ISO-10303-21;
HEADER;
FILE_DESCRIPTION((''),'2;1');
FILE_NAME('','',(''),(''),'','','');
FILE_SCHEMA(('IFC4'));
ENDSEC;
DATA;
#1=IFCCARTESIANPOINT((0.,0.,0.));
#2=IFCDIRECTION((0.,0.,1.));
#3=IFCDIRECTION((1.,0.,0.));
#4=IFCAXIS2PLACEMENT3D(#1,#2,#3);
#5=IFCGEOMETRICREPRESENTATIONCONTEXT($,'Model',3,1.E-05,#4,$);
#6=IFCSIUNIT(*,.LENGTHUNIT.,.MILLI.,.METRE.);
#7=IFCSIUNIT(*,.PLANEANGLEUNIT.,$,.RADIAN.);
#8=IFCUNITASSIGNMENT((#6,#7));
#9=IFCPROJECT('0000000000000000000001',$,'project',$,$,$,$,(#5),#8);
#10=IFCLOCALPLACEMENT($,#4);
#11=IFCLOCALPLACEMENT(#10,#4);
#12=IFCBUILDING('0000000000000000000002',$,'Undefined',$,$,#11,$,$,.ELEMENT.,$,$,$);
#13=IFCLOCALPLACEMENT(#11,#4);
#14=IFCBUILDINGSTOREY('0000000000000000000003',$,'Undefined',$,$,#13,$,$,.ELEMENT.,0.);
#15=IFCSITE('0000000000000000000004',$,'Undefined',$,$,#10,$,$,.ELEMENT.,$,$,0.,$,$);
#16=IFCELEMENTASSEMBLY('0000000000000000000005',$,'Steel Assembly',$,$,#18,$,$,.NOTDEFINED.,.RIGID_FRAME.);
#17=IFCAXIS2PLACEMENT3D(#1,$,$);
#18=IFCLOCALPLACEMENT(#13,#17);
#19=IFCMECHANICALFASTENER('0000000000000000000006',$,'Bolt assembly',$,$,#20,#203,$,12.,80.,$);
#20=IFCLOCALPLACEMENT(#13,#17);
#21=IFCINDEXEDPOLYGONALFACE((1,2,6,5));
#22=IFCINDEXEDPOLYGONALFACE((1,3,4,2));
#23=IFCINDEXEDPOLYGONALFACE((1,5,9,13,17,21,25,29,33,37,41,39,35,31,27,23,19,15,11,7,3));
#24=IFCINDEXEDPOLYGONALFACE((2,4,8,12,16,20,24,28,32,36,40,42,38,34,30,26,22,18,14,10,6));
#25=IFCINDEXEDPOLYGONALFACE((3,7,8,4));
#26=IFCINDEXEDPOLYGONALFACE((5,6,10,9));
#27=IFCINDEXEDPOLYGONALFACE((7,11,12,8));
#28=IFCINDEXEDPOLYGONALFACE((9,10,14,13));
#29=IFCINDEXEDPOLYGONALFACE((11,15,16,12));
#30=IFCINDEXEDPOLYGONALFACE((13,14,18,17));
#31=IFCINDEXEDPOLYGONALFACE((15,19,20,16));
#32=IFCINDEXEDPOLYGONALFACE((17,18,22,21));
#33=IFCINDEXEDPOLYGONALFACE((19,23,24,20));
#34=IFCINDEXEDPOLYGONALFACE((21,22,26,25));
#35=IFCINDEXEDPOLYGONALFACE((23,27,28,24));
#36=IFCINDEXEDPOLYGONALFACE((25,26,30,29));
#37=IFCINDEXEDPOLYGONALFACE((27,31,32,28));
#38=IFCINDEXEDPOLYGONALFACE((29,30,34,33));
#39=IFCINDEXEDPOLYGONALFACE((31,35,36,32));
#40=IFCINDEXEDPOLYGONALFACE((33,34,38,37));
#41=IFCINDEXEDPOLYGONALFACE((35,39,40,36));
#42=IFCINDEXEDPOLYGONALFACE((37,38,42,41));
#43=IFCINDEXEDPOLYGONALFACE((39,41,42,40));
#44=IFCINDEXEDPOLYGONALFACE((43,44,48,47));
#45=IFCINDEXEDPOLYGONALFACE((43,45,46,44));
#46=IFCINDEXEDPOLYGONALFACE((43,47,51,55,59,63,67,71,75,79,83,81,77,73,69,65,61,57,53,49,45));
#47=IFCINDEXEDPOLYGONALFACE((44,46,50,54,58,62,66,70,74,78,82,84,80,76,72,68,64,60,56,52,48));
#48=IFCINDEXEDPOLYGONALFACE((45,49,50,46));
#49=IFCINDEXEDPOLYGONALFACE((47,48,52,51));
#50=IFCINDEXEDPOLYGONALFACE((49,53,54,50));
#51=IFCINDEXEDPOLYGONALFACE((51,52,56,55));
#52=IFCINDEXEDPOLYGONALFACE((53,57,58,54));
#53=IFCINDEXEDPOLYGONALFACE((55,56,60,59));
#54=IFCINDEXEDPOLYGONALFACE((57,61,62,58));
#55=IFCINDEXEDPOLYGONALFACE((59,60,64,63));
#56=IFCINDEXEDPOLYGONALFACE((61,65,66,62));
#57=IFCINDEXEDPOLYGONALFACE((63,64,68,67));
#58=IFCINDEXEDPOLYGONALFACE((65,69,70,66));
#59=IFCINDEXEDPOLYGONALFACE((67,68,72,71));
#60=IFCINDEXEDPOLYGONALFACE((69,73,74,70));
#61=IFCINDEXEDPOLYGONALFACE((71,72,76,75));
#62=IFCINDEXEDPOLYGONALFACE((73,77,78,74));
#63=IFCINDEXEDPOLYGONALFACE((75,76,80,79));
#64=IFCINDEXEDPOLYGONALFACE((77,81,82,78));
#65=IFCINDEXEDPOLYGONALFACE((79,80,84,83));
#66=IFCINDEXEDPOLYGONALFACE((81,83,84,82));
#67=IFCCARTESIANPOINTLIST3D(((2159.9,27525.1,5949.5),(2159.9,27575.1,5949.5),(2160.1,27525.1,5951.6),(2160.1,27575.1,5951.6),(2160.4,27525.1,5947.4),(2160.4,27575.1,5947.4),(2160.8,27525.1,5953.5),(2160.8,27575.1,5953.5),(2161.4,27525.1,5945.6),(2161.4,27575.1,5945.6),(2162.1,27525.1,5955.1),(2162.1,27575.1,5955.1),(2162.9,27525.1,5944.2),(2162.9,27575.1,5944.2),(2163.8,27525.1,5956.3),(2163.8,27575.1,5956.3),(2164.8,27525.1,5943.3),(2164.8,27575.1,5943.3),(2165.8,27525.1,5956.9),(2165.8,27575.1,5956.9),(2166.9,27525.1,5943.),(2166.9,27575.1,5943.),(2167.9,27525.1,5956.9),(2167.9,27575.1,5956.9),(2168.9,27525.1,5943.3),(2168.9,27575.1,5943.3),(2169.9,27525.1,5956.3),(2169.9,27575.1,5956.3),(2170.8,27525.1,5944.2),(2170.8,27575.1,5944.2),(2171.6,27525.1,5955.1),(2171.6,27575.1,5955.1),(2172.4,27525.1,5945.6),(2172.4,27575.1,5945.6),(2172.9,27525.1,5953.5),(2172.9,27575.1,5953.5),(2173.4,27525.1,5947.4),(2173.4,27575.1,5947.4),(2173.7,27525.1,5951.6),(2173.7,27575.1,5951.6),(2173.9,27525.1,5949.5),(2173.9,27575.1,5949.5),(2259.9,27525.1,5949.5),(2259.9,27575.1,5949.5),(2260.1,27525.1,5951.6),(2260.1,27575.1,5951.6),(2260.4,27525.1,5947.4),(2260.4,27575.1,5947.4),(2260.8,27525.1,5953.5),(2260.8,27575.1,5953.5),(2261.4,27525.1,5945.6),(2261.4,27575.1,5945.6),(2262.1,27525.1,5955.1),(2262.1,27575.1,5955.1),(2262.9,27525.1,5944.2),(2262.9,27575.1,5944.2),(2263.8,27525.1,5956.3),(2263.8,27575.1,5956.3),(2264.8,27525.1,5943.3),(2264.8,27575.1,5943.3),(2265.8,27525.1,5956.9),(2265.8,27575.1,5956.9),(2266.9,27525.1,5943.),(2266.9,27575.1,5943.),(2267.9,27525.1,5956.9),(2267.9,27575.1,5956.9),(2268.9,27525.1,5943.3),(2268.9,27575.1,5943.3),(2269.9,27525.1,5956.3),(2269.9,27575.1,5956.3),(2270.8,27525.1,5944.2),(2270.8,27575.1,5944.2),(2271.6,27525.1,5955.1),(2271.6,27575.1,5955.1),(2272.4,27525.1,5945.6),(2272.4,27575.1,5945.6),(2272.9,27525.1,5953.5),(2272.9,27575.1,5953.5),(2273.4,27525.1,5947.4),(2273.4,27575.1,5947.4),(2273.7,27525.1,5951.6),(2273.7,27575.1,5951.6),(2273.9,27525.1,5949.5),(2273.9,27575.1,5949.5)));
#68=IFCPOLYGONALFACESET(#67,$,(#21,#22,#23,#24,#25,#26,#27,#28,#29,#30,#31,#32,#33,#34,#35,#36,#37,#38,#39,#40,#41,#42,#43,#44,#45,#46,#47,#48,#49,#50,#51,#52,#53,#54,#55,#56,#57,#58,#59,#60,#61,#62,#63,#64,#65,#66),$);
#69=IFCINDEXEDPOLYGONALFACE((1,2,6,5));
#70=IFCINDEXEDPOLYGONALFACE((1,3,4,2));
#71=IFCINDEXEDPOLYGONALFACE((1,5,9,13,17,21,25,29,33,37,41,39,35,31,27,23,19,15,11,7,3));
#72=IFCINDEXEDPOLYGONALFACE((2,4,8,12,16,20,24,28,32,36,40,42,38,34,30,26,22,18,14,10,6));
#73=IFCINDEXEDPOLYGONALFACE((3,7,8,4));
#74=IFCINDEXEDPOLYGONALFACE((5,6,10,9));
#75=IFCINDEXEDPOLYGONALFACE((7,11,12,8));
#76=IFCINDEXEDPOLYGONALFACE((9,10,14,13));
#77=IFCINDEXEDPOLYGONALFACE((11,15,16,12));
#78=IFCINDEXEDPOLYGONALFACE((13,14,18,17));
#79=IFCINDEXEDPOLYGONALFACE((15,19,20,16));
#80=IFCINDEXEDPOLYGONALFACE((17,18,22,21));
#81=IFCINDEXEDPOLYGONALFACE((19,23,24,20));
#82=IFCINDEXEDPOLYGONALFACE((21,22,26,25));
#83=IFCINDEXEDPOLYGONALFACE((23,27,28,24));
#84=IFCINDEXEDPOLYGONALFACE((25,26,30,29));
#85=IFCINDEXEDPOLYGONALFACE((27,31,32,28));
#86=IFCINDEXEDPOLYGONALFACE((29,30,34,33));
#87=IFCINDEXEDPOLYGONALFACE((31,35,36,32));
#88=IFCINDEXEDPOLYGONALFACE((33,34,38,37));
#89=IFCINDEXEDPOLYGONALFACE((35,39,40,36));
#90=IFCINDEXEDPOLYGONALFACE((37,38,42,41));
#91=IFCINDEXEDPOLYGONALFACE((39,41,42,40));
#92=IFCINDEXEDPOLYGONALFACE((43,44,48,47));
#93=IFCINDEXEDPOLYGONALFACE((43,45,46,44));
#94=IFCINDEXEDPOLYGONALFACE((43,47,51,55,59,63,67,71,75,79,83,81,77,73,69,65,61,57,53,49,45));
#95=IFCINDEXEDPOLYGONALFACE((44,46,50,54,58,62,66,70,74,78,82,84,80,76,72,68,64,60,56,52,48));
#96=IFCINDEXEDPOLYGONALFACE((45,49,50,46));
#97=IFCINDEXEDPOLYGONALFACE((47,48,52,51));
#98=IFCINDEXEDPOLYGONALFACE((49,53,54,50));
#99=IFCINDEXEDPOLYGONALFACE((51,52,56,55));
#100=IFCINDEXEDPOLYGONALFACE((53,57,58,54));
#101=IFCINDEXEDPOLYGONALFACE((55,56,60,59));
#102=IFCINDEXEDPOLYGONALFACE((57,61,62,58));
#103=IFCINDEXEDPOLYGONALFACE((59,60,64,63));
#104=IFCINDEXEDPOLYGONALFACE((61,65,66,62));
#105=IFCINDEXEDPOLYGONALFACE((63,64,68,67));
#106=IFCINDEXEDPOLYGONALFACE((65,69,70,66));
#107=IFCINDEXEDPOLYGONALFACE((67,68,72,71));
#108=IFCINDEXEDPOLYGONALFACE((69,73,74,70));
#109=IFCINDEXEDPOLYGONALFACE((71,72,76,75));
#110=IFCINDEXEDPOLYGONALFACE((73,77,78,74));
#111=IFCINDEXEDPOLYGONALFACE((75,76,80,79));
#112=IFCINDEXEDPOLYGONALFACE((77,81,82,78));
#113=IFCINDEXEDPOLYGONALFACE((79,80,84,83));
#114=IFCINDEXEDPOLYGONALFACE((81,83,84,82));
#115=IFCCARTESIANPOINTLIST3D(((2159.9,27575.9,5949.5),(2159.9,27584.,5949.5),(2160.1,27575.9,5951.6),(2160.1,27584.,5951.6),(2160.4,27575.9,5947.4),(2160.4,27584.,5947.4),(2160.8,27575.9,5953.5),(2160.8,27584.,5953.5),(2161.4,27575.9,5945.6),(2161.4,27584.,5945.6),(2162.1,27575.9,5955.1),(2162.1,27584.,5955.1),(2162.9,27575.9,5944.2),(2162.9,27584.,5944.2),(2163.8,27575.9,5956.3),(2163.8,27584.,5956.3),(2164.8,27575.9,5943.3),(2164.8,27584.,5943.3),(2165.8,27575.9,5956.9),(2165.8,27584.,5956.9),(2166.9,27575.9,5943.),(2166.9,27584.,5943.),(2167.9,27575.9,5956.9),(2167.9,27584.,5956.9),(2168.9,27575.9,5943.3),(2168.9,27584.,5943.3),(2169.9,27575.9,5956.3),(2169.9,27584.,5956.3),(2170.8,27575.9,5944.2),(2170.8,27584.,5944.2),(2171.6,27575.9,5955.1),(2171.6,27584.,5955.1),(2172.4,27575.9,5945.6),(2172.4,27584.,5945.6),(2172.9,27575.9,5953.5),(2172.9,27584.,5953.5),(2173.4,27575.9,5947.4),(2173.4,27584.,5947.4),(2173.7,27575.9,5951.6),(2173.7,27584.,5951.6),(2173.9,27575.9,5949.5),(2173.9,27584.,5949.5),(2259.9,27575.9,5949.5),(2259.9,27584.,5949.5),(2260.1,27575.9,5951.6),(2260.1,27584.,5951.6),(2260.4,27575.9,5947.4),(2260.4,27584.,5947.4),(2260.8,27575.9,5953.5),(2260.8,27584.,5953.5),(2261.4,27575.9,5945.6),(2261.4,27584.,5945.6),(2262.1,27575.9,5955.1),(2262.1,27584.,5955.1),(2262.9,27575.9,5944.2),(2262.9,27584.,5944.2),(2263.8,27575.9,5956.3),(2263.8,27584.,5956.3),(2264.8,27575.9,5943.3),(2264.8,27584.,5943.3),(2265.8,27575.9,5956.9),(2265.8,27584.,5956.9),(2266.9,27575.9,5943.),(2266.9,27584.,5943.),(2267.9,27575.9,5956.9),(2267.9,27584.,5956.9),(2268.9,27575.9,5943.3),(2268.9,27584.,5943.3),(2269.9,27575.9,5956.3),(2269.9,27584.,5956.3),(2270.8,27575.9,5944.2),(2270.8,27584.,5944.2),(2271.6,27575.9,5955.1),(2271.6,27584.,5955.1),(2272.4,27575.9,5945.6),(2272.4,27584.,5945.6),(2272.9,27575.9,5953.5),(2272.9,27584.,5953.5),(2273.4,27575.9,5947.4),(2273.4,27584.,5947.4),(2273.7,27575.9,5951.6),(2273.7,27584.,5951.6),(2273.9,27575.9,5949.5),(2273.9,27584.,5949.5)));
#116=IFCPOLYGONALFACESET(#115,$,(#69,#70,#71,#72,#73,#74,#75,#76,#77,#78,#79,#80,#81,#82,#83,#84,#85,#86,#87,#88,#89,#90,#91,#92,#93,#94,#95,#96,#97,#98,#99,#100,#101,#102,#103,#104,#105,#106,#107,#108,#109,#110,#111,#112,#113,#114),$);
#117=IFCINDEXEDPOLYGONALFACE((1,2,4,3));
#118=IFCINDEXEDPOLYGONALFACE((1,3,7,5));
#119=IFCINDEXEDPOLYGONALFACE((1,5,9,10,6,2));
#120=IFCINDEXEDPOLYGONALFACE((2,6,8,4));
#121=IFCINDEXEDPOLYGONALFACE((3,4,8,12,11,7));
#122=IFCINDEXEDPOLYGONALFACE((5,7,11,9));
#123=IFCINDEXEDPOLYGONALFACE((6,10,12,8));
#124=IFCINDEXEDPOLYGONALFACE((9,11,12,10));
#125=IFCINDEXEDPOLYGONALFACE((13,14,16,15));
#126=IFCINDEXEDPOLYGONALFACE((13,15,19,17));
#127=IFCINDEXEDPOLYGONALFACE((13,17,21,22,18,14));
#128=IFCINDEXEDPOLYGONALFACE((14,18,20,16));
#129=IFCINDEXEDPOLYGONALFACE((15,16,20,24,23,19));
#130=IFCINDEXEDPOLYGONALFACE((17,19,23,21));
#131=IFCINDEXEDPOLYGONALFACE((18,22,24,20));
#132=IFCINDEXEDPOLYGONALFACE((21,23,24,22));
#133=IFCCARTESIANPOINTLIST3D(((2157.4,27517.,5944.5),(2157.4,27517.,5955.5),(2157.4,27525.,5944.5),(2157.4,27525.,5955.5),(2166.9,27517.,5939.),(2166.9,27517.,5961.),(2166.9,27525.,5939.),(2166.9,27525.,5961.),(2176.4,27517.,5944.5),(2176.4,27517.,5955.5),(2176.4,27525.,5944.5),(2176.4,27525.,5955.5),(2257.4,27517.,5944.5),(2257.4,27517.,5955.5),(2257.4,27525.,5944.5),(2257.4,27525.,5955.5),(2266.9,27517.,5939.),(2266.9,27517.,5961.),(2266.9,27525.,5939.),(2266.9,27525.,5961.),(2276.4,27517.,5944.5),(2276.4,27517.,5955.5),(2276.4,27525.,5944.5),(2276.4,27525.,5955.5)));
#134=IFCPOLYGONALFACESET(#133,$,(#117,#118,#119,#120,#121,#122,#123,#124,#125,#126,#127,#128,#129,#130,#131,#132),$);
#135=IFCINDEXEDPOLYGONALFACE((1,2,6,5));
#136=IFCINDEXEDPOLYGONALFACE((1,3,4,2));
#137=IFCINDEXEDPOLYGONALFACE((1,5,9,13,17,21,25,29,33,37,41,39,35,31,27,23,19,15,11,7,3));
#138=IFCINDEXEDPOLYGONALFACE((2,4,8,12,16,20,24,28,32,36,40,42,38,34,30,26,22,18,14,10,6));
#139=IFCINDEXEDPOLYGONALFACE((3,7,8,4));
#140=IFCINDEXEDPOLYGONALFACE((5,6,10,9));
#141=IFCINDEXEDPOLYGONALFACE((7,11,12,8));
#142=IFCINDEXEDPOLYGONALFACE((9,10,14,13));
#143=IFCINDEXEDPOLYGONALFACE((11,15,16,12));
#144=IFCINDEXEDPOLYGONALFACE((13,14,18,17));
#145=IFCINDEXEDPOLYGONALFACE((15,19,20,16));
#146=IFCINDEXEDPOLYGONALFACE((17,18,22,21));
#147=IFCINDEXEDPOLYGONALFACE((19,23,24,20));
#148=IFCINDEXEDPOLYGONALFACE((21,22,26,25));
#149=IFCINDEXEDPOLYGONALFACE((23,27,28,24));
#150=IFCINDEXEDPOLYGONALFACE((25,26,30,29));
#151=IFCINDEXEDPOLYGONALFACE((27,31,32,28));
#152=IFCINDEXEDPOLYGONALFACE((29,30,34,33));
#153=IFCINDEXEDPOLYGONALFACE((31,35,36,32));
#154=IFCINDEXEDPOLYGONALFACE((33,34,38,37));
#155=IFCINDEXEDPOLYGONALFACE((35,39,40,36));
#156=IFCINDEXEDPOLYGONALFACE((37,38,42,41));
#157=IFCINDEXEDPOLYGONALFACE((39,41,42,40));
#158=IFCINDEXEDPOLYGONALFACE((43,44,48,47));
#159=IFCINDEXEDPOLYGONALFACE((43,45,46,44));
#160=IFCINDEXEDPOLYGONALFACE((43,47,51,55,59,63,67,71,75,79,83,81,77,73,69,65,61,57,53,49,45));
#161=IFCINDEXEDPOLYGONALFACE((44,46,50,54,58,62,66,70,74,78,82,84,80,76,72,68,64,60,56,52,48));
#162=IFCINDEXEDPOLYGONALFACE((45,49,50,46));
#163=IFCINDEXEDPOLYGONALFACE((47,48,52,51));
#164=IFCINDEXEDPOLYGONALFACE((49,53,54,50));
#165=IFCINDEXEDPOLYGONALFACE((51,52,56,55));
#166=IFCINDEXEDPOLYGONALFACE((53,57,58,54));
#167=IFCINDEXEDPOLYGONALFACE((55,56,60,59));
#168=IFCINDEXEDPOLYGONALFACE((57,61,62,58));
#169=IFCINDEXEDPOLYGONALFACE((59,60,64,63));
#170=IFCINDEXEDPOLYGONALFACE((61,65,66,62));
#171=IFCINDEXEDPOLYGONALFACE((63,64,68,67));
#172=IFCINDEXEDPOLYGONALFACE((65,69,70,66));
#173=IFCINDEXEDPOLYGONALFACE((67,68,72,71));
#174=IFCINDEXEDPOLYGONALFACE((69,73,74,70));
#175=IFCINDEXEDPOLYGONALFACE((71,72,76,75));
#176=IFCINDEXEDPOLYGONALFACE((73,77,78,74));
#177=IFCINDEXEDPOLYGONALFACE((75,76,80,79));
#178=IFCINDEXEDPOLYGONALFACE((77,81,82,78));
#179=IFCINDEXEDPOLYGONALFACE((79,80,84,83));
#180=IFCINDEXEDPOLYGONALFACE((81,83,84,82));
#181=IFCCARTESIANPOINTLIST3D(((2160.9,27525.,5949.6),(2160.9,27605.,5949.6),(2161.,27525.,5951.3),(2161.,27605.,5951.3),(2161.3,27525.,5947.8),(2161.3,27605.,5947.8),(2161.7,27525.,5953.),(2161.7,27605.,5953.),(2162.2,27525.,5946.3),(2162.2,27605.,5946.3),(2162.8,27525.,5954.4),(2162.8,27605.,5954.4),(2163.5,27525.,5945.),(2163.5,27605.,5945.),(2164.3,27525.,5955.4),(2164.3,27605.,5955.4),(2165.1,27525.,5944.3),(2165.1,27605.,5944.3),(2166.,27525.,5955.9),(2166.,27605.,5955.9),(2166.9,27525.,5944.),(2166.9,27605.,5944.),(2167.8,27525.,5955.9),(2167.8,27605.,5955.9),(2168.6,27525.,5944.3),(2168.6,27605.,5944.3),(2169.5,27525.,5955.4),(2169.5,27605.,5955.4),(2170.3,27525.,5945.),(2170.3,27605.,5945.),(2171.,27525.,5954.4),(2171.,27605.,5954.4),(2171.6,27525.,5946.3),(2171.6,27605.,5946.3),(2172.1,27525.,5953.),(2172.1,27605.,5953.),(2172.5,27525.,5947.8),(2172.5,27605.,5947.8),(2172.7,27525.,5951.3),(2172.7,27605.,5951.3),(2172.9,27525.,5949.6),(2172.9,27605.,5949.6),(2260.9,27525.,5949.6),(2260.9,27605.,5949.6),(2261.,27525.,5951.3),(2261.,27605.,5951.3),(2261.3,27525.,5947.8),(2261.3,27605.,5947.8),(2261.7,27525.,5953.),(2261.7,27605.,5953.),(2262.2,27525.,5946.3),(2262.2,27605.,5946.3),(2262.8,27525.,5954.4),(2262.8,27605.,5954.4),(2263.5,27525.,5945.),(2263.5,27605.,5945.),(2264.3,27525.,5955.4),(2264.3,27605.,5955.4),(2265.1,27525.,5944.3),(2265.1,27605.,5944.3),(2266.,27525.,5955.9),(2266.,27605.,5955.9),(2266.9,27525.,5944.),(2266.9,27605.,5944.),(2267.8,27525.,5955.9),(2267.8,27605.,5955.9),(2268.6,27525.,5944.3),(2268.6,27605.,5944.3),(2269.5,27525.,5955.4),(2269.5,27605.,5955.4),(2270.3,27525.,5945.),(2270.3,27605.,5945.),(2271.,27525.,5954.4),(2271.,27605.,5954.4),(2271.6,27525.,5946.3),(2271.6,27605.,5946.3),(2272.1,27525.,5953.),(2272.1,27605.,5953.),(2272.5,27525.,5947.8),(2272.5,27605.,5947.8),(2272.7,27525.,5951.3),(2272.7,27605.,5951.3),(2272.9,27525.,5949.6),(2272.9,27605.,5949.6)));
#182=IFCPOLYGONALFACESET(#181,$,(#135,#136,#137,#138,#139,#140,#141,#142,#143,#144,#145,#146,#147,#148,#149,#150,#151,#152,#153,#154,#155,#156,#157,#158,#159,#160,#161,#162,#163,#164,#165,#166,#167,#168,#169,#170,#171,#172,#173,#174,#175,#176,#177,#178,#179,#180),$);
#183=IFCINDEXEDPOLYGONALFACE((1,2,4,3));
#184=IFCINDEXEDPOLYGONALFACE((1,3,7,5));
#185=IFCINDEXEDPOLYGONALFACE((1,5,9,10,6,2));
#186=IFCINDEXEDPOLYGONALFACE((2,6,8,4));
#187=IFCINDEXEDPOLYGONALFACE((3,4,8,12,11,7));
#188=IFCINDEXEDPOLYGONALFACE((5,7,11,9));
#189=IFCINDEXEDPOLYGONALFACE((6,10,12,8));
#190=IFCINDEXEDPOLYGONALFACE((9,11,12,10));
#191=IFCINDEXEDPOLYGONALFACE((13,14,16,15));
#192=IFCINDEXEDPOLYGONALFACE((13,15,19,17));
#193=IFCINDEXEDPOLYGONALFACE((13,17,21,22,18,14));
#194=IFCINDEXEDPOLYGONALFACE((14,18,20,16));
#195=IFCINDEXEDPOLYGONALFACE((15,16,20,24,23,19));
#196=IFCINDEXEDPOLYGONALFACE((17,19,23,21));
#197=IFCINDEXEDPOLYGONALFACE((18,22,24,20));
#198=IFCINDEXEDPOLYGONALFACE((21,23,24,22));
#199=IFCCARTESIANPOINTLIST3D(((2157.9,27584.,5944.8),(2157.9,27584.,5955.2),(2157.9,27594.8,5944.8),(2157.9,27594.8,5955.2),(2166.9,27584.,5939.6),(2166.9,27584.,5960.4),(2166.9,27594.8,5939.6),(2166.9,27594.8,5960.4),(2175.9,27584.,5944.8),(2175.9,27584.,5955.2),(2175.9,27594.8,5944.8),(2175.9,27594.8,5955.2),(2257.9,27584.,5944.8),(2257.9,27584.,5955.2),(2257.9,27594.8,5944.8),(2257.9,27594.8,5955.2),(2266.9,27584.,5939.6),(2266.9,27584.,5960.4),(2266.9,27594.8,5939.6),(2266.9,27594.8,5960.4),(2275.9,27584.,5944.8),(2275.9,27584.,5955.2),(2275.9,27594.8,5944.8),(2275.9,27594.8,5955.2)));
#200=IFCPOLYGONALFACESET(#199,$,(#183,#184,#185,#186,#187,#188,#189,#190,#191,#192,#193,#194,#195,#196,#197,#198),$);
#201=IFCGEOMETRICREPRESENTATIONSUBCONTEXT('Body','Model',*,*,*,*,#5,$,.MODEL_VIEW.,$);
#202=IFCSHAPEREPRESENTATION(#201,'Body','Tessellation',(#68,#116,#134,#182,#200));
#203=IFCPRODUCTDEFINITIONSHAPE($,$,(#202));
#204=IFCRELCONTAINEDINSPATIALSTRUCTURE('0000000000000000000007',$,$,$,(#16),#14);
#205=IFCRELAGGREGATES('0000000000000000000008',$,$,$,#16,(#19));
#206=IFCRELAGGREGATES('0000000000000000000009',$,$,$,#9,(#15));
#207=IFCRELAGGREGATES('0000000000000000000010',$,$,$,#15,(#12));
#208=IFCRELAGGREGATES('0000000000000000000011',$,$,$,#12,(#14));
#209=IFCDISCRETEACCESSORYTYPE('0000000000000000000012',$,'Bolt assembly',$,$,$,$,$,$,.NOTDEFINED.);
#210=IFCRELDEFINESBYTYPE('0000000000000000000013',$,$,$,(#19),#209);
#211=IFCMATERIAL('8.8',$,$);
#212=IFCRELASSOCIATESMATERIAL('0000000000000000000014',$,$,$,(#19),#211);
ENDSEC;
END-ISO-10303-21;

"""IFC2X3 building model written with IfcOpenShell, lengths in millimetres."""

from ifc_helpers import new_model, si_unit, frame, origin_with_axes, origin_2d_with_axis, place, context, subcontext, project, spatial, polyline, circle, outline, extrude, source, transform, mapped, material, type_object, element, aggregate, save


model = new_model("IFC2X3")

# Units and contexts
model_context = context("Model", 3, precision=1e-05, world=origin_with_axes())
body_context = subcontext(model_context, "Body", "Model", "MODEL_VIEW")
ifc_project = project(units=[si_unit("LENGTHUNIT", "METRE", prefix="MILLI"), si_unit("PLANEANGLEUNIT", "RADIAN")], contexts=[model_context])

# Site, building, storey
site_placement = place(None, origin_with_axes())
site = spatial("IfcSite", under=ifc_project, at=site_placement, Name="Undefined", CompositionType="ELEMENT", RefElevation=0.0)
building_placement = place(site_placement, origin_with_axes())
building = spatial("IfcBuilding", under=site, at=building_placement, Name="Undefined", CompositionType="ELEMENT")
storey_placement = place(building_placement, origin_with_axes())
storey = spatial("IfcBuildingStorey", under=building, at=storey_placement, Name="Undefined", CompositionType="ELEMENT", Elevation=0.0)

# Element assembly
assembly_1_placement = place(storey_placement, origin_with_axes())
assembly_1 = element("IfcElementAssembly", 1, at=assembly_1_placement, inside=storey, Name="Steel Assembly", AssemblyPlace="NOTDEFINED", PredefinedType="RIGID_FRAME")

# Shared definitions
ifc_material_1 = material(Name="8.8")
discrete_accessory_type_1 = type_object("IfcDiscreteAccessoryType", Name="Bolt assembly")
shared_shape_1 = source(origin_with_axes(), body_context, "Body", "SweptSolid", [
    extrude(circle(Radius=7.0, at=origin_2d_with_axis()), frame((0.0, -52.9, 0.0), z_axis=(0.0, 1.0, 0.0), x_axis=(1.0, 0.0, 0.0)), (0.0, 0.0, 1.0), 50.0),
    extrude(circle(Radius=7.0, at=origin_2d_with_axis()), frame((0.0, -2.1, 0.0), z_axis=(0.0, 1.0, 0.0), x_axis=(1.0, 0.0, 0.0)), (0.0, 0.0, 1.0), 8.1),
    extrude(outline(polyline([(11.0, 0.0), (5.5, 9.5), (-5.5, 9.5), (-11.0, 0.0), (-5.5, -9.5), (5.5, -9.5), (11.0, 0.0)])), frame((0.0, -61.0, 0.0), z_axis=(0.0, 1.0, 0.0), x_axis=(1.0, 0.0, 0.0)), (0.0, 0.0, 1.0), 8.0),
    extrude(circle(Radius=6.0, at=origin_2d_with_axis()), frame((0.0, -53.0, 0.0), z_axis=(0.0, 1.0, 0.0), x_axis=(1.0, 0.0, 0.0)), (0.0, 0.0, 1.0), 80.0),
    extrude(outline(polyline([(10.4, 0.0), (5.2, 9.0), (-5.2, 9.0), (-10.4, 0.0), (-5.2, -9.0), (5.2, -9.0), (10.4, 0.0)])), frame((0.0, 6.0, 0.0), z_axis=(0.0, 1.0, 0.0), x_axis=(1.0, 0.0, 0.0)), (0.0, 0.0, 1.0), 10.8),
])

# Mechanical fastener
mechanical_fastener_1_placement = place(assembly_1_placement, frame((2216.9, 27578.0, 6000.0), z_axis=(1.0, 0.0, 0.0), x_axis=(0.0, 0.0, -1.0)))
mechanical_fastener_1 = element("IfcMechanicalFastener", 2, at=mechanical_fastener_1_placement, type_object=discrete_accessory_type_1, material=ifc_material_1, Name="Bolt assembly", NominalDiameter=12.0, NominalLength=80.0, context=body_context, shape_type="MappedRepresentation", body=[
    mapped(shared_shape_1, transform((50.0, 0.0, -50.0))),
    mapped(shared_shape_1, transform((50.0, 0.0, 50.0))),
])

aggregate(assembly_1, [mechanical_fastener_1])

save(model, "model.ifc")
